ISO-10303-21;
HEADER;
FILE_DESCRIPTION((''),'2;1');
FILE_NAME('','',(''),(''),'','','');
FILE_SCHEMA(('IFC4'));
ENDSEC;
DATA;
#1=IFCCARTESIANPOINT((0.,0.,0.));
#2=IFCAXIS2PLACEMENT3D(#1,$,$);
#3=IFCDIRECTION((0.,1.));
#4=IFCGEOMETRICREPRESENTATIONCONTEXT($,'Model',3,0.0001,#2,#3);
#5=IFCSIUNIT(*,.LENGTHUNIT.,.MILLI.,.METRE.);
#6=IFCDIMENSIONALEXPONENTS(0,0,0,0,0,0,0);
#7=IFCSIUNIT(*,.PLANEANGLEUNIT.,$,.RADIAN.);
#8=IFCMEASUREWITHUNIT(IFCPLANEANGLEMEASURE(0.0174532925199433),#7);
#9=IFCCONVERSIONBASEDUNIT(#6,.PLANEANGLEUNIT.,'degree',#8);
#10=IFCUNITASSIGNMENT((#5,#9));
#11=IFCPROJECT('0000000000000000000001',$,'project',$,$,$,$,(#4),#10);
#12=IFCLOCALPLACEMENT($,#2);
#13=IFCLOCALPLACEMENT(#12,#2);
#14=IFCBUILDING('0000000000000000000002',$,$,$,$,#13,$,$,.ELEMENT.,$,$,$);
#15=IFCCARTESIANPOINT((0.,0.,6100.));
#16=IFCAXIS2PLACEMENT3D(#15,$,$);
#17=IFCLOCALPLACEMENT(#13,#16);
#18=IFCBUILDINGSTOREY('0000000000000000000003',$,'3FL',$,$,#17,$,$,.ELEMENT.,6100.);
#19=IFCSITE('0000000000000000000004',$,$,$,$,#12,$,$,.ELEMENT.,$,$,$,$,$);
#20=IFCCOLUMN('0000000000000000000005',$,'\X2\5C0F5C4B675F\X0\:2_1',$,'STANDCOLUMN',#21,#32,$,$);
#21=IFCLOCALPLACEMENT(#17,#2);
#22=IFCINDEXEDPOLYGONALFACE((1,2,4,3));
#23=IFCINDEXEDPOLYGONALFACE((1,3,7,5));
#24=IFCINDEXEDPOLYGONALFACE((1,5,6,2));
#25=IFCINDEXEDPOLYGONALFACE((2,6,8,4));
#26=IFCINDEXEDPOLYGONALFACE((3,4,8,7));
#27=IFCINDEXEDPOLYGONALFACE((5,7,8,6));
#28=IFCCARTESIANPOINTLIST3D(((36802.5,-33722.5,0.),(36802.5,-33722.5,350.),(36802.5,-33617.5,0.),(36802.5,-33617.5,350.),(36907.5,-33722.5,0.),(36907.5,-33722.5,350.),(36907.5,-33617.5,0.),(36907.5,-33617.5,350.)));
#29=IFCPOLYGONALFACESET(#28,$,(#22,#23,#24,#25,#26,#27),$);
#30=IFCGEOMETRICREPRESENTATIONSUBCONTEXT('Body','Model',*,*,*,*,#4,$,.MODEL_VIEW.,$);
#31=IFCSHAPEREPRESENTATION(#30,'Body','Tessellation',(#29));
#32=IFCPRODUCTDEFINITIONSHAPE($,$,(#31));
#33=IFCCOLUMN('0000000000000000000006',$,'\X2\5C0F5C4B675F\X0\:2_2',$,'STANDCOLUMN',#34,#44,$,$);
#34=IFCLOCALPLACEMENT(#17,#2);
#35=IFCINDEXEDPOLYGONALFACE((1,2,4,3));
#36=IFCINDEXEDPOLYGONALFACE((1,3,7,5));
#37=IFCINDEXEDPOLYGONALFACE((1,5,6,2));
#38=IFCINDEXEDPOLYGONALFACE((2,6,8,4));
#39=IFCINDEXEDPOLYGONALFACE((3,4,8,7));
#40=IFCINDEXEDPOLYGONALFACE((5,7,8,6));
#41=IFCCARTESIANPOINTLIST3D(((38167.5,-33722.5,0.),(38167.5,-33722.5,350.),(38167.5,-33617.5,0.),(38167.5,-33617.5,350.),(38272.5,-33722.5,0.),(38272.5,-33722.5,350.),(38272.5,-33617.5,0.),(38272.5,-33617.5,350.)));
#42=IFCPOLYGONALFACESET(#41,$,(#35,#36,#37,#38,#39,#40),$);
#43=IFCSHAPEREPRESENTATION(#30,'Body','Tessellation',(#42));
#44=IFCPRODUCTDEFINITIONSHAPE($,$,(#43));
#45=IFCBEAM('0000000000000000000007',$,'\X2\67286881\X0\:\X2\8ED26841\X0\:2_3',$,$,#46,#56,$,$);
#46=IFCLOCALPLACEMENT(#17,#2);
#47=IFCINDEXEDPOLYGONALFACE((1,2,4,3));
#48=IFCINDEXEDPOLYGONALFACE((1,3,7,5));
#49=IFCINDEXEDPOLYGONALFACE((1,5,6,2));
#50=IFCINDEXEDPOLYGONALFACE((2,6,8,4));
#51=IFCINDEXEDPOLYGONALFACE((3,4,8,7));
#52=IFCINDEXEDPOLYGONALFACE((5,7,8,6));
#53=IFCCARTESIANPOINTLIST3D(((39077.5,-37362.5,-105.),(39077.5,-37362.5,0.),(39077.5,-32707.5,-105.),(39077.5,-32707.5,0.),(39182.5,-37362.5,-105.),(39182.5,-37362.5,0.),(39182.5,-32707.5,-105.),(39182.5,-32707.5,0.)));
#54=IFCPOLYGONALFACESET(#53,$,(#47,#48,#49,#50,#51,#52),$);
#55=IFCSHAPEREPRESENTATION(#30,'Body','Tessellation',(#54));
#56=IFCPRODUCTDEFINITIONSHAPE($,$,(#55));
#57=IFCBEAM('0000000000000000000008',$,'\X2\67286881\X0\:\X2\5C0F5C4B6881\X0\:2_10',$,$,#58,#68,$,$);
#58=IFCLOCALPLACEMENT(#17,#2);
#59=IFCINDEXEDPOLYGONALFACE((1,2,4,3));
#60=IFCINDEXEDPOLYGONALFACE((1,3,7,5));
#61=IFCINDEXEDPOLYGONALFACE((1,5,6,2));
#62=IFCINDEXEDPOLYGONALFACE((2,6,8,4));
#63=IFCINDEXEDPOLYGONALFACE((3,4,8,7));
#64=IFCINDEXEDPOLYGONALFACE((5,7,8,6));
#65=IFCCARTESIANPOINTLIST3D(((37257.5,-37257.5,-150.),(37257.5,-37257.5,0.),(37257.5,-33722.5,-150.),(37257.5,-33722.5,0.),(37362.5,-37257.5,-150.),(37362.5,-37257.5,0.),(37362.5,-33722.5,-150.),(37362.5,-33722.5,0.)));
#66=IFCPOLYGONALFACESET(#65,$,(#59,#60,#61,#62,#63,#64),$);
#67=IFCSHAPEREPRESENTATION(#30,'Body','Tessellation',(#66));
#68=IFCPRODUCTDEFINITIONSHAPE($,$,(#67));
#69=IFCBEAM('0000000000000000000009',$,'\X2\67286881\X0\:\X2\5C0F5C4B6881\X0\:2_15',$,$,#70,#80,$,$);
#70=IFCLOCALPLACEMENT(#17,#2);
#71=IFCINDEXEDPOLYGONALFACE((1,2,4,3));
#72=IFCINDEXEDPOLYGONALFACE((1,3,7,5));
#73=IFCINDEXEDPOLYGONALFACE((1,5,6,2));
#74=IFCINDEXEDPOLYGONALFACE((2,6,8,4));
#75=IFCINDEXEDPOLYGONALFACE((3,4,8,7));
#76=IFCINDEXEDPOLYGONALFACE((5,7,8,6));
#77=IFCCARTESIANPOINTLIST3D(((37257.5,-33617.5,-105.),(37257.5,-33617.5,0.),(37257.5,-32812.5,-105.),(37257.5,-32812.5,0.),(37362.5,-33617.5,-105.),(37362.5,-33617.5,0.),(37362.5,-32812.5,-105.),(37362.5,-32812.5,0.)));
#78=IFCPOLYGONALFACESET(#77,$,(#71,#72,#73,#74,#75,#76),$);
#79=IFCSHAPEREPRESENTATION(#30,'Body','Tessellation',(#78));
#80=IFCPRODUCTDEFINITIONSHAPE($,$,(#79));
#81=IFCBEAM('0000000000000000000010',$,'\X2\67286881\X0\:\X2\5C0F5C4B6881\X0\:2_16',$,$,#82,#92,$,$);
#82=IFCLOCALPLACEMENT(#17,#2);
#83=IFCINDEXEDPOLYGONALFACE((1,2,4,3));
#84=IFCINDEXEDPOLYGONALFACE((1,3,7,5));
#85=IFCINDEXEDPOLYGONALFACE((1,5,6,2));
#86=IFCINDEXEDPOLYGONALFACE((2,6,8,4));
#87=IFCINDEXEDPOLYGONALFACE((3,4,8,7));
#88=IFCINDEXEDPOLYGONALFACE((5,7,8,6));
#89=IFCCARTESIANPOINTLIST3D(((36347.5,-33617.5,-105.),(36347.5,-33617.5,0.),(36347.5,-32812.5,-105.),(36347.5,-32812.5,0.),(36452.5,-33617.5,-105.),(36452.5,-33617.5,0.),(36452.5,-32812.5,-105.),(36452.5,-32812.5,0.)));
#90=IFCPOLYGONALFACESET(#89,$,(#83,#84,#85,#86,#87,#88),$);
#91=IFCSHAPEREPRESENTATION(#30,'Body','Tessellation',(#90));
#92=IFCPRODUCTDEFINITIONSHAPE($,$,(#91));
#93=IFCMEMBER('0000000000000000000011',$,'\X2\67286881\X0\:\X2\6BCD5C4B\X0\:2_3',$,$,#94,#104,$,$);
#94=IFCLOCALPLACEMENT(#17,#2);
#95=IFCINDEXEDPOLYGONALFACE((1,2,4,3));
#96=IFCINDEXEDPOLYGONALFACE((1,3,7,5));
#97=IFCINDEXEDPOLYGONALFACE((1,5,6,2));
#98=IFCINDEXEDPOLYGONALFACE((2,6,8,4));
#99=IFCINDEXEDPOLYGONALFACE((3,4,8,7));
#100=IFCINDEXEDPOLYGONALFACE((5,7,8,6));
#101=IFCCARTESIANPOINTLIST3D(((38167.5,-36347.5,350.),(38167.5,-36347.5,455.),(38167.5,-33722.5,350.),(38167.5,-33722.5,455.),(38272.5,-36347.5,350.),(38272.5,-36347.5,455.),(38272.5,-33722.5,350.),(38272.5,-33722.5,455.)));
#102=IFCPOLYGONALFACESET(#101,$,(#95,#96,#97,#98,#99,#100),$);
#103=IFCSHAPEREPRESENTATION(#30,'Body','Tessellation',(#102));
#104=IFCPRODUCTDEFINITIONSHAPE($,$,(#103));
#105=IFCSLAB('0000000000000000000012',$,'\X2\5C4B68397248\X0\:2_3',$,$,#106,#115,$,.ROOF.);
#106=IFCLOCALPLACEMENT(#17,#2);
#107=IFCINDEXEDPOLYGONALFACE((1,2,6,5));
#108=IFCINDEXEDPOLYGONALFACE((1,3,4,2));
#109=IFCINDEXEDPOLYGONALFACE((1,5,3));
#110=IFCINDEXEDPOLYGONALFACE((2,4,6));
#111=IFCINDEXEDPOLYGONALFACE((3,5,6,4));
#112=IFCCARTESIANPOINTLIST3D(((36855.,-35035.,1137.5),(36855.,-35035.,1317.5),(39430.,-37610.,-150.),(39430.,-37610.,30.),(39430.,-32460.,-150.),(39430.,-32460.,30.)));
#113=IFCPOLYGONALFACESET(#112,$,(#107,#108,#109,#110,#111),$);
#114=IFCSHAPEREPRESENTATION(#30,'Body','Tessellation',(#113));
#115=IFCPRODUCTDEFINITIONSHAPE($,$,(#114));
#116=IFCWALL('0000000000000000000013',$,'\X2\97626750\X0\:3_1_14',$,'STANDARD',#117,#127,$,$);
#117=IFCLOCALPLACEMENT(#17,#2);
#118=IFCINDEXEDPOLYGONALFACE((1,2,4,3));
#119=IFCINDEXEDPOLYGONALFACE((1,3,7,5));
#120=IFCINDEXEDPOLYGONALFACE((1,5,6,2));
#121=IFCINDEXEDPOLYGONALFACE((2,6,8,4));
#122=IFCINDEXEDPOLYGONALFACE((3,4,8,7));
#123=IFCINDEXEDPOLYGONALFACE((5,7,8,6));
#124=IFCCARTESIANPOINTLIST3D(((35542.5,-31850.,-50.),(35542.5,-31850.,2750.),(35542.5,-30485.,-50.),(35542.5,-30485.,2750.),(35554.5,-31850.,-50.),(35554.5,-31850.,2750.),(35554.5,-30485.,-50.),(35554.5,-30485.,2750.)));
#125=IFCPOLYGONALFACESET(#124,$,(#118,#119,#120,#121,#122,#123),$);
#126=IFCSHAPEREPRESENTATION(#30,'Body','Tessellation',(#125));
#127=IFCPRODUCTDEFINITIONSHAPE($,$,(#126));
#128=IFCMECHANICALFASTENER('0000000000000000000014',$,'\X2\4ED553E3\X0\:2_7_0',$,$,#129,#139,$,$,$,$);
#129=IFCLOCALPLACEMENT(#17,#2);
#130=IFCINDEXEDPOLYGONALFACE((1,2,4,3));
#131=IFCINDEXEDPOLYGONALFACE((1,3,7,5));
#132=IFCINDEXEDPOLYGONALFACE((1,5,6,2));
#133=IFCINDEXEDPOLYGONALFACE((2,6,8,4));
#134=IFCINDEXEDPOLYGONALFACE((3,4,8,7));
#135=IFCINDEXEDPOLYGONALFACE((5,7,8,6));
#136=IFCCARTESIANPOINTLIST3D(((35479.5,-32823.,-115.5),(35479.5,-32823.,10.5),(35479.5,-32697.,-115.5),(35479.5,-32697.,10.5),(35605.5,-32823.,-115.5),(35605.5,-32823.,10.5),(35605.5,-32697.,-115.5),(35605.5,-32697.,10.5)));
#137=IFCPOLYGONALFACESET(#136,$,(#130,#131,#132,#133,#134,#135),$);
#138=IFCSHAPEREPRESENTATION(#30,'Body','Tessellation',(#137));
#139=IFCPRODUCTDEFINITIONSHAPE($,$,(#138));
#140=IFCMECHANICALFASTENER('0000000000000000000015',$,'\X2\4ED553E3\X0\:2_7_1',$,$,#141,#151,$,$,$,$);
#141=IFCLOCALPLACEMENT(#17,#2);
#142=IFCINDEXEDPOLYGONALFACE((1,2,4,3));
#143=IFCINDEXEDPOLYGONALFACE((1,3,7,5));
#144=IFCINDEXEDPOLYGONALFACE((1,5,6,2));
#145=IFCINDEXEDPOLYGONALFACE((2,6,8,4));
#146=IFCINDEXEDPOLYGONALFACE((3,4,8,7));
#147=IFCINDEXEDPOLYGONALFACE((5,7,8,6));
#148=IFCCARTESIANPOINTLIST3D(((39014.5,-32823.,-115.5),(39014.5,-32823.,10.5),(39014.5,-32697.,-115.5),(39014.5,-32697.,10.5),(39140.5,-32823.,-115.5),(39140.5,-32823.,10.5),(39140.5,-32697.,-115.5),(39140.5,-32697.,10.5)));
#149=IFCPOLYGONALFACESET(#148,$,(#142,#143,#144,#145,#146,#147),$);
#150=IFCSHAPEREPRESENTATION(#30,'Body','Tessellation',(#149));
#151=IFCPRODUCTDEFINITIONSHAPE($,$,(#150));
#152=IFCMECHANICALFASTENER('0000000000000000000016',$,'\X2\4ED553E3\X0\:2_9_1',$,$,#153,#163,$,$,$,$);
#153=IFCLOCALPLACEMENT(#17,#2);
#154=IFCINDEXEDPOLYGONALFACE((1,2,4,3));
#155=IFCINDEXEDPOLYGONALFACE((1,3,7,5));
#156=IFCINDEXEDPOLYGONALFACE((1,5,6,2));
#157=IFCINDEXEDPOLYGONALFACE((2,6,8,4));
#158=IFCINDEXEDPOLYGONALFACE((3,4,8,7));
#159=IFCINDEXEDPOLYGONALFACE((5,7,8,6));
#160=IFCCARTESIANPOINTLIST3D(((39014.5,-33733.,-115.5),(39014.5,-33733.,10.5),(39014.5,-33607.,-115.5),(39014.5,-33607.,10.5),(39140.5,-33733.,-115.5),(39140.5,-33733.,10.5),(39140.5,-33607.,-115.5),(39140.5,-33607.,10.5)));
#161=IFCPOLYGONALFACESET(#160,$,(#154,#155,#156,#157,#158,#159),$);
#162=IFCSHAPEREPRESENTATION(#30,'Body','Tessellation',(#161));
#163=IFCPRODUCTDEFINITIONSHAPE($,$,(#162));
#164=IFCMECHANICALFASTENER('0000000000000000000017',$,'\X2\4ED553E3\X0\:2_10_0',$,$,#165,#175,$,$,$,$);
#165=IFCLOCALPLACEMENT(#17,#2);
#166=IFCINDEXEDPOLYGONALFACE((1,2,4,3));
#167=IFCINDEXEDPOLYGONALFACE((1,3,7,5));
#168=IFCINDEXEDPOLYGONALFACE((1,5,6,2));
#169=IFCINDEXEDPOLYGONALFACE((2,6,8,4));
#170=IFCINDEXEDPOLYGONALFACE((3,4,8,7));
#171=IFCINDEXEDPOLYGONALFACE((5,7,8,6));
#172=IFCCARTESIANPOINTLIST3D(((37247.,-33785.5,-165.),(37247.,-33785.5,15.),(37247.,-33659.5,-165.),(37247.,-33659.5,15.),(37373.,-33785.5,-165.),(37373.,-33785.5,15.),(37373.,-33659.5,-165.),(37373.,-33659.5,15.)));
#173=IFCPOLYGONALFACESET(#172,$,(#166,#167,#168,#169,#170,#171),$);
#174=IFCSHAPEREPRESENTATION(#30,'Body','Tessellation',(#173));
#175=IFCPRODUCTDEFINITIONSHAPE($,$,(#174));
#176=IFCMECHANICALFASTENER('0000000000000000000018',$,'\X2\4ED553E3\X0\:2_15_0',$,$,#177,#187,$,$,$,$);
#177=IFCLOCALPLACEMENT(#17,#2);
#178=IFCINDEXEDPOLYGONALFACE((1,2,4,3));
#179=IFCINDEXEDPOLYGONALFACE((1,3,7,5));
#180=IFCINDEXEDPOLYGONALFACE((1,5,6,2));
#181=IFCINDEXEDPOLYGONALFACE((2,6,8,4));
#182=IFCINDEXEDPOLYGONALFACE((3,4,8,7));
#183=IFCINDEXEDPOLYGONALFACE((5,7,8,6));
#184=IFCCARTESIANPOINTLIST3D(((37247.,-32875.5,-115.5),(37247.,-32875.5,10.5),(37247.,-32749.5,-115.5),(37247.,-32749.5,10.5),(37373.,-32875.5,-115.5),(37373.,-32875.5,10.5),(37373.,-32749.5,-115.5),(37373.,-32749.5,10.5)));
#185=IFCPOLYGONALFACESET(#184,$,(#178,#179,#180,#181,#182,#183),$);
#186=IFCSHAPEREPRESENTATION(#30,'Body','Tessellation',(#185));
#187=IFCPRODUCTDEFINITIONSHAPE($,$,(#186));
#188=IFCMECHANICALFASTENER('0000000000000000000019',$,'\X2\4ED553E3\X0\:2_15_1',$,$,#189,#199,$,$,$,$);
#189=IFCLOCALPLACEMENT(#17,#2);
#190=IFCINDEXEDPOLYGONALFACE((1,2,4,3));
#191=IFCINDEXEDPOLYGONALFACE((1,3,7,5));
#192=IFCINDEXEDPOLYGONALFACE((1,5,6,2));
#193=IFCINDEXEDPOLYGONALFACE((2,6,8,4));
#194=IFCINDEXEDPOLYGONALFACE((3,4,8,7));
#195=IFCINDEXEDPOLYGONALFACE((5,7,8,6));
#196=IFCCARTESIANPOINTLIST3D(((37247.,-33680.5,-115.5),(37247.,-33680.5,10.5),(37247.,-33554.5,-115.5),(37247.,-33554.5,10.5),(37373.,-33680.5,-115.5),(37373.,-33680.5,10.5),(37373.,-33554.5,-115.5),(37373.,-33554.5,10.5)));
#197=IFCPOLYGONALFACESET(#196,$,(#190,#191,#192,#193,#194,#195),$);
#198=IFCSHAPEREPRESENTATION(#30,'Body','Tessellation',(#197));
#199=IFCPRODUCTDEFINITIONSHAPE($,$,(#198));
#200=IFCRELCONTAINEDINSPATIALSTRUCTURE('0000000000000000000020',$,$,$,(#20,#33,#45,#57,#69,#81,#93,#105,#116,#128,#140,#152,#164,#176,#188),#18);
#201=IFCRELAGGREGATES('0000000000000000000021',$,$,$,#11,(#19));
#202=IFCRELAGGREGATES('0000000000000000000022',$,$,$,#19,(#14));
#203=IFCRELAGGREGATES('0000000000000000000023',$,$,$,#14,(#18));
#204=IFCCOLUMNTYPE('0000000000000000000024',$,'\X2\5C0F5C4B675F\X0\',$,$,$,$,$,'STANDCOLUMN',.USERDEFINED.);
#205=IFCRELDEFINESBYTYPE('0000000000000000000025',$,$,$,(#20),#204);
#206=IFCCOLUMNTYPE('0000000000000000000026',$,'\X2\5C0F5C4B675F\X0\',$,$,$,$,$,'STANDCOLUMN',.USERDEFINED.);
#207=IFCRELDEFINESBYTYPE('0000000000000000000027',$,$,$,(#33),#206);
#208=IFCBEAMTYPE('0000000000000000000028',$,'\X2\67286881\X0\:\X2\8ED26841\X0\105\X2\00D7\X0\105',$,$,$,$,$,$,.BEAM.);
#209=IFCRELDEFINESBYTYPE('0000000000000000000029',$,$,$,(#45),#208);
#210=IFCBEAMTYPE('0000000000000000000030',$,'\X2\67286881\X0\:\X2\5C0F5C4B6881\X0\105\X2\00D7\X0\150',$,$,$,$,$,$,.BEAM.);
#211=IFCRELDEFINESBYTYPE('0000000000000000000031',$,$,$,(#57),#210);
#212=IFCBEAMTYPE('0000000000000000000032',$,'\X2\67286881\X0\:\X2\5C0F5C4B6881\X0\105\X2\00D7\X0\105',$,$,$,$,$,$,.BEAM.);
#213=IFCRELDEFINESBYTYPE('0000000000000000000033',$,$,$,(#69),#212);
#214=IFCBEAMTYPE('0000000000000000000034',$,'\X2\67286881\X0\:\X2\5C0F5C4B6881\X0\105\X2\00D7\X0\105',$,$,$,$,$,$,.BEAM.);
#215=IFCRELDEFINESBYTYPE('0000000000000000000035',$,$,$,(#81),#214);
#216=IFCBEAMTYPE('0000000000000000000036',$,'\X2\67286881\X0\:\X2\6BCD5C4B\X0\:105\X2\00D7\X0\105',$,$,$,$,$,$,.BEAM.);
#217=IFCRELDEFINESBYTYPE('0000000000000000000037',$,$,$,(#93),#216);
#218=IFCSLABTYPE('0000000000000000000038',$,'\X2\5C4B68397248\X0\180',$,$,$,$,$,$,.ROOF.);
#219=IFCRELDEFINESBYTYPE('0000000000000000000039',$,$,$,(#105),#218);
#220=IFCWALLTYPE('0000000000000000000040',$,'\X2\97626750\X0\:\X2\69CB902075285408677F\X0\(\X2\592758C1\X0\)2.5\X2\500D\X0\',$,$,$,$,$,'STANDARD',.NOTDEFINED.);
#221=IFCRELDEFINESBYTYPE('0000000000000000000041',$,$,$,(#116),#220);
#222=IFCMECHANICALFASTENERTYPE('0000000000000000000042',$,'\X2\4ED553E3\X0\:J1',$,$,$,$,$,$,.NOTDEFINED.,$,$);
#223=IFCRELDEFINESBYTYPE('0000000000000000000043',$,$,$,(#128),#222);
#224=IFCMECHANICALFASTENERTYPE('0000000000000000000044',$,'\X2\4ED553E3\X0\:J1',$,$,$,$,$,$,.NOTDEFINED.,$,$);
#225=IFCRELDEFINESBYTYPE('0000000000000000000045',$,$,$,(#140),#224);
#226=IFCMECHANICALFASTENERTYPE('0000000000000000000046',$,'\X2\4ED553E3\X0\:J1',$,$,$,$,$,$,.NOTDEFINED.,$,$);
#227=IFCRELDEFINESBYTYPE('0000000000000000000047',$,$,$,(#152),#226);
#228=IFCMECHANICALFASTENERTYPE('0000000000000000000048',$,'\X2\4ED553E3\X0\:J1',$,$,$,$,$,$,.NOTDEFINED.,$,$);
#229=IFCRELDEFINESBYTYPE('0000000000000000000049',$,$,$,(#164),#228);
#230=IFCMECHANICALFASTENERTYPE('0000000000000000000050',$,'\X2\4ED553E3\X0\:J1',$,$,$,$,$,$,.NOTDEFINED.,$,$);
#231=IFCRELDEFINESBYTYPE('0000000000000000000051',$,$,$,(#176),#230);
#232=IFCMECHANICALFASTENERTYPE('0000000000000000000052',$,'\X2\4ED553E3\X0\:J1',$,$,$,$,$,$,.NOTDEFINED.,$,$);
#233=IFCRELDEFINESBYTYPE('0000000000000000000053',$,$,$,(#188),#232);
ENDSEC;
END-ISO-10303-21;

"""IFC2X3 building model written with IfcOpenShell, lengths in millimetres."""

from ifc_helpers import new_model, entity, si_unit, converted_unit, direction, frame, origin, origin_with_axes, origin_2d, place, context, subcontext, project, spatial, polyline, rectangle, outline, extrude, type_object, element, save


model = new_model("IFC2X3")

# Units and contexts
model_context = context("Model", 3, precision=0.0001, world=origin(), true_north=direction((0.0, 1.0)))
body_context = subcontext(model_context, "Body", "Model", "MODEL_VIEW")
ifc_project = project(units=[si_unit("LENGTHUNIT", "METRE", prefix="MILLI"), converted_unit("PLANEANGLEUNIT", "degree", entity("IfcPlaneAngleMeasure", 0.0174532925199433), si_unit("PLANEANGLEUNIT", "RADIAN"), dimensions=[0, 0, 0, 0, 0, 0, 0])], contexts=[model_context])

# Site, building, storey
site_placement = place(None, origin())
site = spatial("IfcSite", under=ifc_project, at=site_placement, CompositionType="ELEMENT")
building_placement = place(site_placement, origin())
building = spatial("IfcBuilding", under=site, at=building_placement, CompositionType="ELEMENT")
storey_placement = place(building_placement, frame((0.0, 0.0, 6100.0)))
storey = spatial("IfcBuildingStorey", under=building, at=storey_placement, Name="3FL", CompositionType="ELEMENT", Elevation=6100.0)

# Columns
column_type_1 = type_object("IfcColumnType", Name="小屋束", ElementType="STANDCOLUMN", PredefinedType="USERDEFINED")
column_1_placement = place(storey_placement, frame((36855.0, -33670.0, 0.0)))
element("IfcColumn", 1, at=column_1_placement, inside=storey, type_object=column_type_1, Name="小屋束:2_1", ObjectType="STANDCOLUMN", context=body_context, shape_type="SweptSolid", body=[
    extrude(rectangle(XDim=105.0, YDim=105.0, at=origin_2d()), origin_with_axes(), (0.0, 0.0, 1.0), 350.0),
])
column_type_2 = type_object("IfcColumnType", Name="小屋束", ElementType="STANDCOLUMN", PredefinedType="USERDEFINED")
column_2_placement = place(storey_placement, frame((38220.0, -33670.0, 0.0)))
element("IfcColumn", 2, at=column_2_placement, inside=storey, type_object=column_type_2, Name="小屋束:2_2", ObjectType="STANDCOLUMN", context=body_context, shape_type="SweptSolid", body=[
    extrude(rectangle(XDim=105.0, YDim=105.0, at=origin_2d()), origin_with_axes(), (0.0, 0.0, 1.0), 350.0),
])

# Beams
beam_type_1 = type_object("IfcBeamType", Name="木梁:軒桁105×105", PredefinedType="BEAM")
beam_1_placement = place(storey_placement, frame((39130.0, -32707.5, -52.5), z_axis=(0.0, -1.0, 0.0), x_axis=(1.0, 0.0, 0.0)))
element("IfcBeam", 3, at=beam_1_placement, inside=storey, type_object=beam_type_1, Name="木梁:軒桁:2_3", context=body_context, shape_type="SweptSolid", body=[
    extrude(rectangle(XDim=105.0, YDim=105.0, at=origin_2d()), origin_with_axes(), (0.0, 0.0, 1.0), 4655.0),
])
beam_type_2 = type_object("IfcBeamType", Name="木梁:小屋梁105×150", PredefinedType="BEAM")
beam_2_placement = place(storey_placement, frame((37310.0, -33722.5, -75.0), z_axis=(0.0, -1.0, 0.0), x_axis=(1.0, 0.0, 0.0)))
element("IfcBeam", 4, at=beam_2_placement, inside=storey, type_object=beam_type_2, Name="木梁:小屋梁:2_10", context=body_context, shape_type="SweptSolid", body=[
    extrude(rectangle(XDim=105.0, YDim=150.0, at=origin_2d()), origin_with_axes(), (0.0, 0.0, 1.0), 3535.0),
])
beam_type_3 = type_object("IfcBeamType", Name="木梁:小屋梁105×105", PredefinedType="BEAM")
beam_3_placement = place(storey_placement, frame((37310.0, -32812.5, -52.5), z_axis=(0.0, -1.0, 0.0), x_axis=(1.0, 0.0, 0.0)))
element("IfcBeam", 5, at=beam_3_placement, inside=storey, type_object=beam_type_3, Name="木梁:小屋梁:2_15", context=body_context, shape_type="SweptSolid", body=[
    extrude(rectangle(XDim=105.0, YDim=105.0, at=origin_2d()), origin_with_axes(), (0.0, 0.0, 1.0), 805.0),
])
beam_type_4 = type_object("IfcBeamType", Name="木梁:小屋梁105×105", PredefinedType="BEAM")
beam_4_placement = place(storey_placement, frame((36400.0, -32812.5, -52.5), z_axis=(0.0, -1.0, 0.0), x_axis=(1.0, 0.0, 0.0)))
element("IfcBeam", 6, at=beam_4_placement, inside=storey, type_object=beam_type_4, Name="木梁:小屋梁:2_16", context=body_context, shape_type="SweptSolid", body=[
    extrude(rectangle(XDim=105.0, YDim=105.0, at=origin_2d()), origin_with_axes(), (0.0, 0.0, 1.0), 805.0),
])

# Member
beam_type_5 = type_object("IfcBeamType", Name="木梁:母屋:105×105", PredefinedType="BEAM")
member_1_placement = place(storey_placement, frame((38220.0, -33722.5, 402.5), z_axis=(0.0, -1.0, 0.0), x_axis=(-1.0, 0.0, 0.0)))
element("IfcMember", 7, at=member_1_placement, inside=storey, type_object=beam_type_5, Name="木梁:母屋:2_3", context=body_context, shape_type="SweptSolid", body=[
    extrude(rectangle(XDim=105.0, YDim=105.0, at=origin_2d()), origin_with_axes(), (0.0, 0.0, 1.0), 2625.0),
])

# Slab
slab_type = type_object("IfcSlabType", Name="屋根版180", PredefinedType="ROOF")
slab_placement = place(storey_placement, frame((39430.0, -32460.0, -150.0), z_axis=(-0.447214, 0.0, -0.894427), x_axis=(0.0, -1.0, 0.0)))
element("IfcSlab", 8, at=slab_placement, inside=storey, type_object=slab_type, Name="屋根版:2_3", PredefinedType="ROOF", context=body_context, shape_type="SweptSolid", body=[
    extrude(outline(polyline([(0.0, 0.0, 0.0), (5150.0, 0.0, 0.0), (2575.0, 2878.9, 0.0), (0.0, 0.0, 0.0)])), origin_with_axes(), (0.0, 0.447214, -0.894427), 180.0),
])

# Wall
wall_type = type_object("IfcWallType", Name="面材:構造用合板(大壁)2.5倍", ElementType="STANDARD", PredefinedType="NOTDEFINED")
wall_placement = place(storey_placement, frame((35554.5, -31167.5, -50.0), z_axis=(-1.0, 0.0, 0.0), x_axis=(0.0, -1.0, 0.0)))
element("IfcWall", 9, at=wall_placement, inside=storey, type_object=wall_type, Name="面材:3_1_14", ObjectType="STANDARD", context=body_context, shape_type="SweptSolid", body=[
    extrude(outline(polyline([(682.5, 0.0, 0.0), (-682.5, 0.0, 0.0), (-682.5, 2800.0, 0.0), (682.5, 2800.0, 0.0), (682.5, 0.0, 0.0)])), origin_with_axes(), (0.0, 0.0, 1.0), 12.0),
])

# Mechanical fasteners
mechanical_fastener_type_1 = type_object("IfcMechanicalFastenerType", Name="仕口:J1")
mechanical_fastener_1_placement = place(storey_placement, frame((35542.5, -32760.0, -115.5)))
element("IfcMechanicalFastener", 10, at=mechanical_fastener_1_placement, inside=storey, type_object=mechanical_fastener_type_1, Name="仕口:2_7_0", context=body_context, shape_type="SweptSolid", body=[
    extrude(rectangle(XDim=126.0, YDim=126.0, at=origin_2d()), origin_with_axes(), (0.0, 0.0, 1.0), 126.0),
])
mechanical_fastener_type_2 = type_object("IfcMechanicalFastenerType", Name="仕口:J1")
mechanical_fastener_2_placement = place(storey_placement, frame((39077.5, -32760.0, -115.5)))
element("IfcMechanicalFastener", 11, at=mechanical_fastener_2_placement, inside=storey, type_object=mechanical_fastener_type_2, Name="仕口:2_7_1", context=body_context, shape_type="SweptSolid", body=[
    extrude(rectangle(XDim=126.0, YDim=126.0, at=origin_2d()), origin_with_axes(), (0.0, 0.0, 1.0), 126.0),
])
mechanical_fastener_type_3 = type_object("IfcMechanicalFastenerType", Name="仕口:J1")
mechanical_fastener_3_placement = place(storey_placement, frame((39077.5, -33670.0, -115.5)))
element("IfcMechanicalFastener", 12, at=mechanical_fastener_3_placement, inside=storey, type_object=mechanical_fastener_type_3, Name="仕口:2_9_1", context=body_context, shape_type="SweptSolid", body=[
    extrude(rectangle(XDim=126.0, YDim=126.0, at=origin_2d()), origin_with_axes(), (0.0, 0.0, 1.0), 126.0),
])
mechanical_fastener_type_4 = type_object("IfcMechanicalFastenerType", Name="仕口:J1")
mechanical_fastener_4_placement = place(storey_placement, frame((37310.0, -33722.5, -165.0)))
element("IfcMechanicalFastener", 13, at=mechanical_fastener_4_placement, inside=storey, type_object=mechanical_fastener_type_4, Name="仕口:2_10_0", context=body_context, shape_type="SweptSolid", body=[
    extrude(rectangle(XDim=126.0, YDim=126.0, at=origin_2d()), origin_with_axes(), (0.0, 0.0, 1.0), 180.0),
])
mechanical_fastener_type_5 = type_object("IfcMechanicalFastenerType", Name="仕口:J1")
mechanical_fastener_5_placement = place(storey_placement, frame((37310.0, -32812.5, -115.5)))
element("IfcMechanicalFastener", 14, at=mechanical_fastener_5_placement, inside=storey, type_object=mechanical_fastener_type_5, Name="仕口:2_15_0", context=body_context, shape_type="SweptSolid", body=[
    extrude(rectangle(XDim=126.0, YDim=126.0, at=origin_2d()), origin_with_axes(), (0.0, 0.0, 1.0), 126.0),
])
mechanical_fastener_type_6 = type_object("IfcMechanicalFastenerType", Name="仕口:J1")
mechanical_fastener_6_placement = place(storey_placement, frame((37310.0, -33617.5, -115.5)))
element("IfcMechanicalFastener", 15, at=mechanical_fastener_6_placement, inside=storey, type_object=mechanical_fastener_type_6, Name="仕口:2_15_1", context=body_context, shape_type="SweptSolid", body=[
    extrude(rectangle(XDim=126.0, YDim=126.0, at=origin_2d()), origin_with_axes(), (0.0, 0.0, 1.0), 126.0),
])

save(model, "model.ifc")
